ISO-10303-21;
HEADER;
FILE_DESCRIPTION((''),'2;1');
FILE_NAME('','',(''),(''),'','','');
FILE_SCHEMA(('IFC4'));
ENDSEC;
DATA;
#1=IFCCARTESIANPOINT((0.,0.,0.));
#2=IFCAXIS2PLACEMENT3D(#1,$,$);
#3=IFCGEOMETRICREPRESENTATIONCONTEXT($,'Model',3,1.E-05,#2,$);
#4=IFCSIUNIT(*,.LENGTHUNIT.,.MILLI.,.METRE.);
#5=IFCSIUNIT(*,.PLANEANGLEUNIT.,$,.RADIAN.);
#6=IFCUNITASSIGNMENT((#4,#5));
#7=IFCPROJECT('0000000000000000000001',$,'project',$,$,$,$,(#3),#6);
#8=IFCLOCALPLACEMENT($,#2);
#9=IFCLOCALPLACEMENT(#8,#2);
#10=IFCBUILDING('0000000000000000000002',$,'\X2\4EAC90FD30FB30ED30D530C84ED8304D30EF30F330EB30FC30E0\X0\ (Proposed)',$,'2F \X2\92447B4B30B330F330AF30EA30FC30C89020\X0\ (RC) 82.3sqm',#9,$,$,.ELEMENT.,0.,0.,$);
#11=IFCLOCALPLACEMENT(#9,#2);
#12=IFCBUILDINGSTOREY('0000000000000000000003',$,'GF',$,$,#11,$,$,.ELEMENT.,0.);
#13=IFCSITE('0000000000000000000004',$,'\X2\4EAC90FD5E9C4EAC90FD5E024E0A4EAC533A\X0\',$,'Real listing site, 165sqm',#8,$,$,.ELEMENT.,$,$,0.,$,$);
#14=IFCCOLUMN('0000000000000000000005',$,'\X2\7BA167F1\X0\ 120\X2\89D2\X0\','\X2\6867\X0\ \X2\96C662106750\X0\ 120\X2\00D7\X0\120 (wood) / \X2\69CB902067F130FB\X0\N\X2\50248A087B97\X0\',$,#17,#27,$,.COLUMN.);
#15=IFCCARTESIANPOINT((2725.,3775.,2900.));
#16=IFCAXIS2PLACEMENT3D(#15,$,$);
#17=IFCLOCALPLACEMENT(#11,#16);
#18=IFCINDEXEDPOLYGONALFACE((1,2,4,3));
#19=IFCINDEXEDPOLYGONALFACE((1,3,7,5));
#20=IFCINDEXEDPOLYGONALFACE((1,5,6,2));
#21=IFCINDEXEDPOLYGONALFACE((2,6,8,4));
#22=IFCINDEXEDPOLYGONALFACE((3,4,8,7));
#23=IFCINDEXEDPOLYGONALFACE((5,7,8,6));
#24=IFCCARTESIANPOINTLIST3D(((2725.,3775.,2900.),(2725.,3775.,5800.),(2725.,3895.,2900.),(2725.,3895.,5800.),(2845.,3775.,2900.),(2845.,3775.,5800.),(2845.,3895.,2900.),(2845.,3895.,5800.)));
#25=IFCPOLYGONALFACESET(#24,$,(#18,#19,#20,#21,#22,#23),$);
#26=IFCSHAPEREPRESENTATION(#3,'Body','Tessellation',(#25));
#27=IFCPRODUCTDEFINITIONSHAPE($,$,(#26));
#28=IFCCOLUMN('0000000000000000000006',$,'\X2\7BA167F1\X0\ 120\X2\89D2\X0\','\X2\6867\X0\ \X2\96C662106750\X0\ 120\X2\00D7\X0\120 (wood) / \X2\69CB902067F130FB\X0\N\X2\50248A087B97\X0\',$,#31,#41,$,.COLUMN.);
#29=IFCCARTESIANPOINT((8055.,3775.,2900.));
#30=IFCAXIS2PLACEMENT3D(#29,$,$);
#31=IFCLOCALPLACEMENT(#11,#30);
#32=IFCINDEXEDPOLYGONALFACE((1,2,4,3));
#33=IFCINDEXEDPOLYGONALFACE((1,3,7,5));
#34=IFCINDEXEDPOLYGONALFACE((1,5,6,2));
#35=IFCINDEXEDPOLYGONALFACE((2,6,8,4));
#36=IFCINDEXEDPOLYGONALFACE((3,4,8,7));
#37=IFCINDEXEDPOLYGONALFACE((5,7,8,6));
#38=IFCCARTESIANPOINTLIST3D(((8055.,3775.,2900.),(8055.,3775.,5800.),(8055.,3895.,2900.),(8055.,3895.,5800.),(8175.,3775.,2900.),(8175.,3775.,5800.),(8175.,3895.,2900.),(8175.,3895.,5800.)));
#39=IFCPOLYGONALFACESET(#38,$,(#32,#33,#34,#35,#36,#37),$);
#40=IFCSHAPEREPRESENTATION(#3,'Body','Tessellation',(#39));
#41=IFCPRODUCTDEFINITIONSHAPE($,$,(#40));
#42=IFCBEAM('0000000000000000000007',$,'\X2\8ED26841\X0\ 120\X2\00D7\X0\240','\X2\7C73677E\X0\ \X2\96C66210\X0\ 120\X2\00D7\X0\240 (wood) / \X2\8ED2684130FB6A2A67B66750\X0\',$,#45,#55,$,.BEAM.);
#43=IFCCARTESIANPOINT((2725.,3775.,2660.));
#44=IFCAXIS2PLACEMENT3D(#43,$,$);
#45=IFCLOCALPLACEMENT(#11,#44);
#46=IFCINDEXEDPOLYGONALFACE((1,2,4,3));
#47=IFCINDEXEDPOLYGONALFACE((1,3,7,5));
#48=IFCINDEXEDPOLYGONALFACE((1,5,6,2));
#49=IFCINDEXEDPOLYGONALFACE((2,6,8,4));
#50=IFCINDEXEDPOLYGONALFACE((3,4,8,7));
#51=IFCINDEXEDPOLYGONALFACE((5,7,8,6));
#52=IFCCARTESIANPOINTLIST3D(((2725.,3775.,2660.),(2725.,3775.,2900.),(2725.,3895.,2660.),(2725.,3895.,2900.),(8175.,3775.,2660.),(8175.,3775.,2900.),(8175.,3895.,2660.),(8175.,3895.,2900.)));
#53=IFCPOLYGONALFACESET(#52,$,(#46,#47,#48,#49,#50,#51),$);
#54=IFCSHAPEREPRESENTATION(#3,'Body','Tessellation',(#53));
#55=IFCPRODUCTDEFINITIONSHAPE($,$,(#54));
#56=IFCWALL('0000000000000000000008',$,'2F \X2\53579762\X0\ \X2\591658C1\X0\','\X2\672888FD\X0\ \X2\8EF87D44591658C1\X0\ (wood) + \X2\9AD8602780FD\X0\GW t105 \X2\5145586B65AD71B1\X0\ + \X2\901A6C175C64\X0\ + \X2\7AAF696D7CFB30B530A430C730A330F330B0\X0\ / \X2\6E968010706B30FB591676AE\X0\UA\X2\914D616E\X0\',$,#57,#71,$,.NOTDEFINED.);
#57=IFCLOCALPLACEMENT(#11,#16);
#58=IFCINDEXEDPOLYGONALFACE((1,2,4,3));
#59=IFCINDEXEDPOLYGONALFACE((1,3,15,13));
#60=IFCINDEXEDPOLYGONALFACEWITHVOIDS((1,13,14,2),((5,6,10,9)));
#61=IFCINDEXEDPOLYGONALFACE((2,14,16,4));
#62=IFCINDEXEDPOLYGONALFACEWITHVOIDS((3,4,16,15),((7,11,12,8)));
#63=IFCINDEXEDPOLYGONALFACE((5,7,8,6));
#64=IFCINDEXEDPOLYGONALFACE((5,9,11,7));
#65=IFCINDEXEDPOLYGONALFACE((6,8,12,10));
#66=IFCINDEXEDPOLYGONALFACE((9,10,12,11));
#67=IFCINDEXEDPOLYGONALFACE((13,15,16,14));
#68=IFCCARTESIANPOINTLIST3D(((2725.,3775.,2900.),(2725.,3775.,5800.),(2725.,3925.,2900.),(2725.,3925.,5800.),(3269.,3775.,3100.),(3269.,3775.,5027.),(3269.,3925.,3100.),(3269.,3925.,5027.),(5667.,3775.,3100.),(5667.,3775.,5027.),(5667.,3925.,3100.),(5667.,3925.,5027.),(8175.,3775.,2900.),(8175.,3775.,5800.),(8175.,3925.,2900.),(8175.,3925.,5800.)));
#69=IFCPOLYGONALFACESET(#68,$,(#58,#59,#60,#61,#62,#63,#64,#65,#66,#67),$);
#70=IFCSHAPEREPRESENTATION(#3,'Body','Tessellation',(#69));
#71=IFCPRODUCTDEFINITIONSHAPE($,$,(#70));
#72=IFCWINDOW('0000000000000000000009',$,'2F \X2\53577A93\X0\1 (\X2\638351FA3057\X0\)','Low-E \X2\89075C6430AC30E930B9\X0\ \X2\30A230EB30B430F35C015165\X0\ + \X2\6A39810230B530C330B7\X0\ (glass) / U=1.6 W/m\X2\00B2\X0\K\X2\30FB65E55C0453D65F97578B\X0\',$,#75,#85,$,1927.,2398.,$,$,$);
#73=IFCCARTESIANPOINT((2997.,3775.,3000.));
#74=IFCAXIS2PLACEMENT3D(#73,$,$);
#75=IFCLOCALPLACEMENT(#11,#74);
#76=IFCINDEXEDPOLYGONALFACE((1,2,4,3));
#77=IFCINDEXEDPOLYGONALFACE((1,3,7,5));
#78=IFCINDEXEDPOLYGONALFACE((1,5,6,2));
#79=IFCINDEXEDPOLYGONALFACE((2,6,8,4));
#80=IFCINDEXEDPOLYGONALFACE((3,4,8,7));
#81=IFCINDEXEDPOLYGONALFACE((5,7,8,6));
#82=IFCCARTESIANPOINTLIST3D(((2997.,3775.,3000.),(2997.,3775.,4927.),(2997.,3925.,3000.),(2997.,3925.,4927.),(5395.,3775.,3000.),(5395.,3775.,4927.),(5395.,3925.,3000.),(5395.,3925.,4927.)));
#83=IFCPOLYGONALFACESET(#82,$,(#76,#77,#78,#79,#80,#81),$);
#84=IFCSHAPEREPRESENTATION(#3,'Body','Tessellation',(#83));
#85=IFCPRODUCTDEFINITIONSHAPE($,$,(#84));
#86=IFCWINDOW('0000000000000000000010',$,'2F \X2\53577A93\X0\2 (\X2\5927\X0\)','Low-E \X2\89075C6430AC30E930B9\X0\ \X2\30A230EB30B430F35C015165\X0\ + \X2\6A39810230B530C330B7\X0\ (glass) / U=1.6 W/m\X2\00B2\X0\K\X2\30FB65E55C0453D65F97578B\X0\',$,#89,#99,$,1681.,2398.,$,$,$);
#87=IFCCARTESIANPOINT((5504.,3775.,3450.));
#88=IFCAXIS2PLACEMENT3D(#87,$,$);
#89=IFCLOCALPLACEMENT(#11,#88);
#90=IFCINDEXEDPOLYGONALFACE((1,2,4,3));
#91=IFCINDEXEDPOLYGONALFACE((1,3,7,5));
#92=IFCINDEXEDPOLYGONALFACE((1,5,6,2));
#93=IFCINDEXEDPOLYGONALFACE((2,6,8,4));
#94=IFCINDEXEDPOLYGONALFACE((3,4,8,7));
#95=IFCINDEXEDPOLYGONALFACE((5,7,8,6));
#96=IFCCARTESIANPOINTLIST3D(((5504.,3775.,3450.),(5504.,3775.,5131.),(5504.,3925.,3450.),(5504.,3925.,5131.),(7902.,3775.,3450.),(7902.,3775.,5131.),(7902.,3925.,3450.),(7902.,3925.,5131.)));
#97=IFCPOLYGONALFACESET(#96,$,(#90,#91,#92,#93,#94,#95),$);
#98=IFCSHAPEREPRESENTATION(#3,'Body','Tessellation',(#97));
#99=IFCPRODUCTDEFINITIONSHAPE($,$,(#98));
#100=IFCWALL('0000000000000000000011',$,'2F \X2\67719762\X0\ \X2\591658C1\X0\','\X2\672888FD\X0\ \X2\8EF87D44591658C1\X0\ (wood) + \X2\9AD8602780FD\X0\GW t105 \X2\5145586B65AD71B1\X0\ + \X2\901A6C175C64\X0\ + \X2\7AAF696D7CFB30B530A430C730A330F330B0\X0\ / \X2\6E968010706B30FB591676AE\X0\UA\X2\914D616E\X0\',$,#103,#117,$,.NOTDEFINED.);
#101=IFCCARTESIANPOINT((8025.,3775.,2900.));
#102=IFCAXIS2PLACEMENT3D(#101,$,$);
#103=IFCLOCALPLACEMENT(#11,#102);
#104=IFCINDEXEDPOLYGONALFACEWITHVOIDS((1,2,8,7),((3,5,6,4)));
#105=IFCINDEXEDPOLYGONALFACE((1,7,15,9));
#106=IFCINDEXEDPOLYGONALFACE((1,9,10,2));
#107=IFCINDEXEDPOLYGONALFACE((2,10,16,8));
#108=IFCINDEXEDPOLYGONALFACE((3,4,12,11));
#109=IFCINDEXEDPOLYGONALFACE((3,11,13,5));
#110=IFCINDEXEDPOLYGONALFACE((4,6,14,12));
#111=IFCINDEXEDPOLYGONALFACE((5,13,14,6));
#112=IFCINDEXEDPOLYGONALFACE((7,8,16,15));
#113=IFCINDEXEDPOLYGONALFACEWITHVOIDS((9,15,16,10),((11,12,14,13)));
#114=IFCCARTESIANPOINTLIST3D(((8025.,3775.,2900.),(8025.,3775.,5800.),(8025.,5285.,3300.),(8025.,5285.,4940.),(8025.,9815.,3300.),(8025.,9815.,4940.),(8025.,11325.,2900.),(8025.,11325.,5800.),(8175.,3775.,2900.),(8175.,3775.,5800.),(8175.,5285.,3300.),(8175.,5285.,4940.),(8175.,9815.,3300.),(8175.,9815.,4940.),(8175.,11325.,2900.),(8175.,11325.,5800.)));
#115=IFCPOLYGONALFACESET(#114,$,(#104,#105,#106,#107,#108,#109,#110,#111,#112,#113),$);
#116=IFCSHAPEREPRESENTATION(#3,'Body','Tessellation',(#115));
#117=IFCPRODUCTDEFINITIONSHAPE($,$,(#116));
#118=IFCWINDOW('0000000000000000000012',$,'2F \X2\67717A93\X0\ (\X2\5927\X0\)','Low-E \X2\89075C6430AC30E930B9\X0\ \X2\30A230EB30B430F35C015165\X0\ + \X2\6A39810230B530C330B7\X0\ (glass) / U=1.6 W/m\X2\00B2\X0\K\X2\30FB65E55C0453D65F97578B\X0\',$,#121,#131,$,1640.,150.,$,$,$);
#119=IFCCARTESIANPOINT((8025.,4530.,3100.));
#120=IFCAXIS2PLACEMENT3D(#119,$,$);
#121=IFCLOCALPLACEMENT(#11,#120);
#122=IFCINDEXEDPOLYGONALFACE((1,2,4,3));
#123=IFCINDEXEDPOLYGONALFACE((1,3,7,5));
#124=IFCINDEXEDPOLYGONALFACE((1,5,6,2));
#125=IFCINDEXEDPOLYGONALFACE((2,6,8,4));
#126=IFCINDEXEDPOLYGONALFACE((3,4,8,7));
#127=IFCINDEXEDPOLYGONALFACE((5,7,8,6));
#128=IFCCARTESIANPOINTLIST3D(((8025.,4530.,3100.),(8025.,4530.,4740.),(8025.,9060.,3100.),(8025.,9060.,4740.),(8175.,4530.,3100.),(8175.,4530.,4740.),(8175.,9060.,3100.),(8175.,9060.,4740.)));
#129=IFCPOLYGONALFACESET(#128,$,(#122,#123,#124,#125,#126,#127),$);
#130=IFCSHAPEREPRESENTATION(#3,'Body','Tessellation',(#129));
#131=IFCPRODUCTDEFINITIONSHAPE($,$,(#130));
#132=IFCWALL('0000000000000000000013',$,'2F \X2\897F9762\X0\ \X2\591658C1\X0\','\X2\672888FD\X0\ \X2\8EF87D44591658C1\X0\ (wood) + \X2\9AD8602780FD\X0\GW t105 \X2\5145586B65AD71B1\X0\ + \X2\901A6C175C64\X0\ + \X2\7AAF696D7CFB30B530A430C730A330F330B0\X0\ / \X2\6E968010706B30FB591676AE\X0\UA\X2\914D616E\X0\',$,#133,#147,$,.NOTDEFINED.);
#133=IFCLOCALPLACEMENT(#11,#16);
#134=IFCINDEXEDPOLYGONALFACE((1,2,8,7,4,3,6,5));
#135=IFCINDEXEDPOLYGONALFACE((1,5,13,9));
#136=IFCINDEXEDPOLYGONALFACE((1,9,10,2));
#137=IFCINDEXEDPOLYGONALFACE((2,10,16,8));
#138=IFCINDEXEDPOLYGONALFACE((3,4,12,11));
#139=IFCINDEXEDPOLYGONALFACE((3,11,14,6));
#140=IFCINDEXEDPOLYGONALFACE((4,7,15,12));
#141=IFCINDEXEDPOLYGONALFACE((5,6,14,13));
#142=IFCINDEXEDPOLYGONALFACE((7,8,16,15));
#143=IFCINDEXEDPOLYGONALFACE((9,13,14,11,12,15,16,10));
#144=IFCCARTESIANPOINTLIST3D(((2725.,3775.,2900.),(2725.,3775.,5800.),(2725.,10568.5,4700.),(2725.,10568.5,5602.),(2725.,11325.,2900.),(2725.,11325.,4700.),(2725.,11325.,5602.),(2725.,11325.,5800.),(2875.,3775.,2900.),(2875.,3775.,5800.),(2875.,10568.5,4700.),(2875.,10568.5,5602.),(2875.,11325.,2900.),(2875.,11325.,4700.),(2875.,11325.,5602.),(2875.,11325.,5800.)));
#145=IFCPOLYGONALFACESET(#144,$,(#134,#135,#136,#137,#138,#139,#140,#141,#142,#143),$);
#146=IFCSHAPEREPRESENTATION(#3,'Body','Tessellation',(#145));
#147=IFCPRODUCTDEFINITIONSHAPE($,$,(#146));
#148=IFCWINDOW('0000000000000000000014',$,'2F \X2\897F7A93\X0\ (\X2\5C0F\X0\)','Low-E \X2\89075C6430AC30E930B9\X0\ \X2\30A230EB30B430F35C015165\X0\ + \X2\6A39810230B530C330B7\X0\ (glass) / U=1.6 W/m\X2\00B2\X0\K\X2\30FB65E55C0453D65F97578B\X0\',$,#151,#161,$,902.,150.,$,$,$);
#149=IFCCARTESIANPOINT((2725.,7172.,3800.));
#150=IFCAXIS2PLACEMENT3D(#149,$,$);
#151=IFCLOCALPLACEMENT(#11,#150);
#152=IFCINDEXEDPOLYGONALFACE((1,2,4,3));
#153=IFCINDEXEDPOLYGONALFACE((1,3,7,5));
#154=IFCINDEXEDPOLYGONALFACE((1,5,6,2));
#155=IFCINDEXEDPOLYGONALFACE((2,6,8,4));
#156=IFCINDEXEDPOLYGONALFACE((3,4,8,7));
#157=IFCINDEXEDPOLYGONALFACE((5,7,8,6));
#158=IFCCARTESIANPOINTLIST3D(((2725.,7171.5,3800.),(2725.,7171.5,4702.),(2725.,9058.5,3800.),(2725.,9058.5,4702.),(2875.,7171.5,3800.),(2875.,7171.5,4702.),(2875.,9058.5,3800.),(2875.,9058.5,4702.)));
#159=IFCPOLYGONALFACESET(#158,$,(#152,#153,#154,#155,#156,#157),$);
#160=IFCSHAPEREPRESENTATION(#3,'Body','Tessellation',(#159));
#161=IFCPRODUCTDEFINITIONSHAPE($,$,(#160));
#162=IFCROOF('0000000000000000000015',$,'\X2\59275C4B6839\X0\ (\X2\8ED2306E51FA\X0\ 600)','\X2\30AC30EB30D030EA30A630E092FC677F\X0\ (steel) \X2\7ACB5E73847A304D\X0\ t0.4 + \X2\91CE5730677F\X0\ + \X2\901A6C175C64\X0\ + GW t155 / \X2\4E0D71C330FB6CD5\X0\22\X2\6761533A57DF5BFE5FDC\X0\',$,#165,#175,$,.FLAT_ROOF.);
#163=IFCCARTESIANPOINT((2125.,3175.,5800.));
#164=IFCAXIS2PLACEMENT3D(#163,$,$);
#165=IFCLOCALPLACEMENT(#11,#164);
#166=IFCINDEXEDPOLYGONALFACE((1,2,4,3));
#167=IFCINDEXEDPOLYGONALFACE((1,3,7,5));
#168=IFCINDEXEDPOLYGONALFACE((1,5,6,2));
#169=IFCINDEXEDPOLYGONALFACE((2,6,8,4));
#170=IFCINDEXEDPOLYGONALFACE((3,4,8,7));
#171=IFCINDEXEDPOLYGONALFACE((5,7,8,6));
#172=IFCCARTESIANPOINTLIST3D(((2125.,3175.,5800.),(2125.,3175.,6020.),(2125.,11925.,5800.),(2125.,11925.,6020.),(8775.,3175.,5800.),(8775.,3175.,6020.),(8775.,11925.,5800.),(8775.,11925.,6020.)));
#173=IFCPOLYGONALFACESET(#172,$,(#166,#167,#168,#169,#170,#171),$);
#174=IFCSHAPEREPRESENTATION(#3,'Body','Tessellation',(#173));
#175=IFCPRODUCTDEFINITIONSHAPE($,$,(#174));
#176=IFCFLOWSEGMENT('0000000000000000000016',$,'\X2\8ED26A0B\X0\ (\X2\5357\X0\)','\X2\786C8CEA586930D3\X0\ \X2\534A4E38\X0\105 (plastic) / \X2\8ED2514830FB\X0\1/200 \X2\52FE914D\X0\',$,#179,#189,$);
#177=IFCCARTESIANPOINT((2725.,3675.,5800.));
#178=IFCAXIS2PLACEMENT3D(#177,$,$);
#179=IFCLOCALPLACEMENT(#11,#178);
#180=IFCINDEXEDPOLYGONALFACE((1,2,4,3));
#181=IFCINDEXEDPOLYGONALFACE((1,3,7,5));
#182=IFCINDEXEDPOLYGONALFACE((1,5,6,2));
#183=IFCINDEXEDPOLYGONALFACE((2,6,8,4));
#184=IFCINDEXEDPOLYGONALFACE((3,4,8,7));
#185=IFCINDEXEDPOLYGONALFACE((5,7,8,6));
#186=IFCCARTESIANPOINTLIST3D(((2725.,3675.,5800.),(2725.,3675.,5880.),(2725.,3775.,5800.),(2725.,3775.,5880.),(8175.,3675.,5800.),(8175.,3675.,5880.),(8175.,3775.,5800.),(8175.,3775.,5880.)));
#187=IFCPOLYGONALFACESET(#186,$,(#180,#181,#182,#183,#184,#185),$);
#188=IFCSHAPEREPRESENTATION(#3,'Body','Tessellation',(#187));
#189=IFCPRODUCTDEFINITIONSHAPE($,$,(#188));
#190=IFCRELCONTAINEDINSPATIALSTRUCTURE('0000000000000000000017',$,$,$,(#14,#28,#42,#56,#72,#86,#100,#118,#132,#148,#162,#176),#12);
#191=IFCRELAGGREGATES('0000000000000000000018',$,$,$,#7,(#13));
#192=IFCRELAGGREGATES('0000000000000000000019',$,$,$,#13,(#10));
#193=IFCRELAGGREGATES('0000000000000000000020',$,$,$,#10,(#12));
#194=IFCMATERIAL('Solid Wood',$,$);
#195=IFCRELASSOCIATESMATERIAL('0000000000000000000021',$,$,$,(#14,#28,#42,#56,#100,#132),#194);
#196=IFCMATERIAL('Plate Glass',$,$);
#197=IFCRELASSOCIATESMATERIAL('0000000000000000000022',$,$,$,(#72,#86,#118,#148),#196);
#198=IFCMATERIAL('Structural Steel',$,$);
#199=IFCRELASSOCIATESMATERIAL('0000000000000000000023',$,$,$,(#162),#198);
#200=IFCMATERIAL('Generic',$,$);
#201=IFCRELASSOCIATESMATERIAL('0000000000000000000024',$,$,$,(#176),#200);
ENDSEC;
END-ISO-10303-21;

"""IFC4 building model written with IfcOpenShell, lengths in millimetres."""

from ifc_helpers import new_model, si_unit, frame, frame_2d, origin, place, context, project, spatial, rectangle, extrude, material, element, fill, save


model = new_model("IFC4")

# Units and contexts
model_context = context("Model", 3, precision=1e-05, world=origin())
ifc_project = project(units=[si_unit("LENGTHUNIT", "METRE", prefix="MILLI"), si_unit("PLANEANGLEUNIT", "RADIAN")], contexts=[model_context])

# Site, building, storey
site_placement = place(None, origin())
site = spatial("IfcSite", under=ifc_project, at=site_placement, Name="京都府京都市上京区", ObjectType="Real listing site, 165sqm", CompositionType="ELEMENT", RefElevation=0.0)
building_placement = place(site_placement, origin())
building = spatial("IfcBuilding", under=site, at=building_placement, Name="京都・ロフト付きワンルーム (Proposed)", ObjectType="2F 鉄筋コンクリート造 (RC) 82.3sqm", CompositionType="ELEMENT", ElevationOfRefHeight=0.0, ElevationOfTerrain=0.0)
storey_placement = place(building_placement, origin())
storey = spatial("IfcBuildingStorey", under=building, at=storey_placement, Name="GF", CompositionType="ELEMENT", Elevation=0.0)

# Columns
ifc_material_1 = material(Name="Solid Wood")
column_1_placement = place(storey_placement, frame((2725.0, 3775.0, 2900.0)))
element("IfcColumn", 1, at=column_1_placement, inside=storey, material=ifc_material_1, Name="管柱 120角", Description="桧 集成材 120×120 (wood) / 構造柱・N値計算", PredefinedType="COLUMN", context=model_context, shape_type="SweptSolid", body=[
    extrude(rectangle(XDim=120.0, YDim=120.0, at=frame_2d((60.0, 60.0))), frame((2725.0, 3775.0, 2900.0)), (0.0, 0.0, 1.0), 2900.0),
])
column_2_placement = place(storey_placement, frame((8055.0, 3775.0, 2900.0)))
element("IfcColumn", 2, at=column_2_placement, inside=storey, material=ifc_material_1, Name="管柱 120角", Description="桧 集成材 120×120 (wood) / 構造柱・N値計算", PredefinedType="COLUMN", context=model_context, shape_type="SweptSolid", body=[
    extrude(rectangle(XDim=120.0, YDim=120.0, at=frame_2d((60.0, 60.0))), frame((8055.0, 3775.0, 2900.0)), (0.0, 0.0, 1.0), 2900.0),
])

# Beam
beam_1_placement = place(storey_placement, frame((2725.0, 3775.0, 2660.0)))
element("IfcBeam", 3, at=beam_1_placement, inside=storey, material=ifc_material_1, Name="軒桁 120×240", Description="米松 集成 120×240 (wood) / 軒桁・横架材", PredefinedType="BEAM", context=model_context, shape_type="SweptSolid", body=[
    extrude(rectangle(XDim=5450.0, YDim=120.0, at=frame_2d((2725.0, 60.0))), frame((2725.0, 3775.0, 2660.0)), (0.0, 0.0, 1.0), 240.0),
])

# Wall, openings, windows
wall_1_placement = place(storey_placement, frame((2725.0, 3775.0, 2900.0)))
wall_1 = element("IfcWall", 4, at=wall_1_placement, inside=storey, material=ifc_material_1, Name="2F 南面 外壁", Description="木製 軸組外壁 (wood) + 高性能GW t105 充填断熱 + 通気層 + 窯業系サイディング / 準耐火・外皮UA配慮", PredefinedType="NOTDEFINED", context=model_context, shape_type="SweptSolid", body=[
    extrude(rectangle(XDim=5450.0, YDim=150.0, at=frame_2d((2725.0, 75.0))), frame((2725.0, 3775.0, 2900.0)), (0.0, 0.0, 1.0), 2900.0),
])
opening_1_placement = place(storey_placement, frame((2997.0, 3775.0, 3000.0)))
opening_1 = element("IfcOpeningElement", 5, at=opening_1_placement, cuts=wall_1, PredefinedType="NOTDEFINED", context=model_context, shape_type="SweptSolid", body=[
    extrude(rectangle(XDim=2398.0, YDim=150.0, at=frame_2d((1199.0, 75.0))), frame((2997.0, 3775.0, 3000.0)), (0.0, 0.0, 1.0), 1927.0),
])
opening_2_placement = place(storey_placement, frame((5504.0, 3775.0, 3450.0)))
opening_2 = element("IfcOpeningElement", 6, at=opening_2_placement, cuts=wall_1, PredefinedType="NOTDEFINED", context=model_context, shape_type="SweptSolid", body=[
    extrude(rectangle(XDim=2398.0, YDim=150.0, at=frame_2d((1199.0, 75.0))), frame((5504.0, 3775.0, 3450.0)), (0.0, 0.0, 1.0), 1681.0),
])
ifc_material_2 = material(Name="Plate Glass")
window_1_placement = place(storey_placement, frame((2997.0, 3775.0, 3000.0)))
window_1 = element("IfcWindow", 7, at=window_1_placement, inside=storey, material=ifc_material_2, Name="2F 南窓1 (掃出し)", Description="Low-E 複層ガラス アルゴン封入 + 樹脂サッシ (glass) / U=1.6 W/m²K・日射取得型", OverallHeight=1927.0, OverallWidth=2398.0, context=model_context, shape_type="SweptSolid", body=[
    extrude(rectangle(XDim=2398.0, YDim=150.0, at=frame_2d((1199.0, 75.0))), frame((2997.0, 3775.0, 3000.0)), (0.0, 0.0, 1.0), 1927.0),
])
fill(opening_1, window_1)
window_2_placement = place(storey_placement, frame((5504.0, 3775.0, 3450.0)))
window_2 = element("IfcWindow", 8, at=window_2_placement, inside=storey, material=ifc_material_2, Name="2F 南窓2 (大)", Description="Low-E 複層ガラス アルゴン封入 + 樹脂サッシ (glass) / U=1.6 W/m²K・日射取得型", OverallHeight=1681.0, OverallWidth=2398.0, context=model_context, shape_type="SweptSolid", body=[
    extrude(rectangle(XDim=2398.0, YDim=150.0, at=frame_2d((1199.0, 75.0))), frame((5504.0, 3775.0, 3450.0)), (0.0, 0.0, 1.0), 1681.0),
])
fill(opening_2, window_2)

# Walls, openings, windows
wall_2_placement = place(storey_placement, frame((8025.0, 3775.0, 2900.0)))
wall_2 = element("IfcWall", 9, at=wall_2_placement, inside=storey, material=ifc_material_1, Name="2F 東面 外壁", Description="木製 軸組外壁 (wood) + 高性能GW t105 充填断熱 + 通気層 + 窯業系サイディング / 準耐火・外皮UA配慮", PredefinedType="NOTDEFINED", context=model_context, shape_type="SweptSolid", body=[
    extrude(rectangle(XDim=150.0, YDim=7550.0, at=frame_2d((75.0, 3775.0))), frame((8025.0, 3775.0, 2900.0)), (0.0, 0.0, 1.0), 2900.0),
])
opening_3_placement = place(storey_placement, frame((8025.0, 4530.0, 3100.0)))
opening_3 = element("IfcOpeningElement", 10, at=opening_3_placement, cuts=wall_2, PredefinedType="NOTDEFINED", context=model_context, shape_type="SweptSolid", body=[
    extrude(rectangle(XDim=150.0, YDim=4530.0, at=frame_2d((75.0, 2265.0))), frame((8025.0, 4530.0, 3100.0)), (0.0, 0.0, 1.0), 1640.0),
])
window_3_placement = place(storey_placement, frame((8025.0, 4530.0, 3100.0)))
window_3 = element("IfcWindow", 11, at=window_3_placement, inside=storey, material=ifc_material_2, Name="2F 東窓 (大)", Description="Low-E 複層ガラス アルゴン封入 + 樹脂サッシ (glass) / U=1.6 W/m²K・日射取得型", OverallHeight=1640.0, OverallWidth=150.0, context=model_context, shape_type="SweptSolid", body=[
    extrude(rectangle(XDim=150.0, YDim=4530.0, at=frame_2d((75.0, 2265.0))), frame((8025.0, 4530.0, 3100.0)), (0.0, 0.0, 1.0), 1640.0),
])
fill(opening_3, window_3)
wall_3_placement = place(storey_placement, frame((2725.0, 3775.0, 2900.0)))
wall_3 = element("IfcWall", 12, at=wall_3_placement, inside=storey, material=ifc_material_1, Name="2F 西面 外壁", Description="木製 軸組外壁 (wood) + 高性能GW t105 充填断熱 + 通気層 + 窯業系サイディング / 準耐火・外皮UA配慮", PredefinedType="NOTDEFINED", context=model_context, shape_type="SweptSolid", body=[
    extrude(rectangle(XDim=150.0, YDim=7550.0, at=frame_2d((75.0, 3775.0))), frame((2725.0, 3775.0, 2900.0)), (0.0, 0.0, 1.0), 2900.0),
])
opening_4_placement = place(storey_placement, frame((2725.0, 7172.0, 3800.0)))
opening_4 = element("IfcOpeningElement", 13, at=opening_4_placement, cuts=wall_3, PredefinedType="NOTDEFINED", context=model_context, shape_type="SweptSolid", body=[
    extrude(rectangle(XDim=150.0, YDim=1887.0, at=frame_2d((75.0, 943.0))), frame((2725.0, 7172.0, 3800.0)), (0.0, 0.0, 1.0), 902.0),
])
window_4_placement = place(storey_placement, frame((2725.0, 7172.0, 3800.0)))
window_4 = element("IfcWindow", 14, at=window_4_placement, inside=storey, material=ifc_material_2, Name="2F 西窓 (小)", Description="Low-E 複層ガラス アルゴン封入 + 樹脂サッシ (glass) / U=1.6 W/m²K・日射取得型", OverallHeight=902.0, OverallWidth=150.0, context=model_context, shape_type="SweptSolid", body=[
    extrude(rectangle(XDim=150.0, YDim=1887.0, at=frame_2d((75.0, 943.0))), frame((2725.0, 7172.0, 3800.0)), (0.0, 0.0, 1.0), 902.0),
])
fill(opening_4, window_4)

# Roof
ifc_material_3 = material(Name="Structural Steel")
roof_placement = place(storey_placement, frame((2125.0, 3175.0, 5800.0)))
element("IfcRoof", 15, at=roof_placement, inside=storey, material=ifc_material_3, Name="大屋根 (軒の出 600)", Description="ガルバリウム鋼板 (steel) 立平葺き t0.4 + 野地板 + 通気層 + GW t155 / 不燃・法22条区域対応", PredefinedType="FLAT_ROOF", context=model_context, shape_type="SweptSolid", body=[
    extrude(rectangle(XDim=6650.0, YDim=8750.0, at=frame_2d((3325.0, 4375.0))), frame((2125.0, 3175.0, 5800.0)), (0.0, 0.0, 1.0), 220.0),
])

# Flow segment
ifc_material_4 = material(Name="Generic")
flow_segment_placement = place(storey_placement, frame((2725.0, 3675.0, 5800.0)))
element("IfcFlowSegment", 16, at=flow_segment_placement, inside=storey, material=ifc_material_4, Name="軒樋 (南)", Description="硬質塩ビ 半丸105 (plastic) / 軒先・1/200 勾配", context=model_context, shape_type="SweptSolid", body=[
    extrude(rectangle(XDim=5450.0, YDim=100.0, at=frame_2d((2725.0, 50.0))), frame((2725.0, 3675.0, 5800.0)), (0.0, 0.0, 1.0), 80.0),
])

save(model, "model.ifc")
